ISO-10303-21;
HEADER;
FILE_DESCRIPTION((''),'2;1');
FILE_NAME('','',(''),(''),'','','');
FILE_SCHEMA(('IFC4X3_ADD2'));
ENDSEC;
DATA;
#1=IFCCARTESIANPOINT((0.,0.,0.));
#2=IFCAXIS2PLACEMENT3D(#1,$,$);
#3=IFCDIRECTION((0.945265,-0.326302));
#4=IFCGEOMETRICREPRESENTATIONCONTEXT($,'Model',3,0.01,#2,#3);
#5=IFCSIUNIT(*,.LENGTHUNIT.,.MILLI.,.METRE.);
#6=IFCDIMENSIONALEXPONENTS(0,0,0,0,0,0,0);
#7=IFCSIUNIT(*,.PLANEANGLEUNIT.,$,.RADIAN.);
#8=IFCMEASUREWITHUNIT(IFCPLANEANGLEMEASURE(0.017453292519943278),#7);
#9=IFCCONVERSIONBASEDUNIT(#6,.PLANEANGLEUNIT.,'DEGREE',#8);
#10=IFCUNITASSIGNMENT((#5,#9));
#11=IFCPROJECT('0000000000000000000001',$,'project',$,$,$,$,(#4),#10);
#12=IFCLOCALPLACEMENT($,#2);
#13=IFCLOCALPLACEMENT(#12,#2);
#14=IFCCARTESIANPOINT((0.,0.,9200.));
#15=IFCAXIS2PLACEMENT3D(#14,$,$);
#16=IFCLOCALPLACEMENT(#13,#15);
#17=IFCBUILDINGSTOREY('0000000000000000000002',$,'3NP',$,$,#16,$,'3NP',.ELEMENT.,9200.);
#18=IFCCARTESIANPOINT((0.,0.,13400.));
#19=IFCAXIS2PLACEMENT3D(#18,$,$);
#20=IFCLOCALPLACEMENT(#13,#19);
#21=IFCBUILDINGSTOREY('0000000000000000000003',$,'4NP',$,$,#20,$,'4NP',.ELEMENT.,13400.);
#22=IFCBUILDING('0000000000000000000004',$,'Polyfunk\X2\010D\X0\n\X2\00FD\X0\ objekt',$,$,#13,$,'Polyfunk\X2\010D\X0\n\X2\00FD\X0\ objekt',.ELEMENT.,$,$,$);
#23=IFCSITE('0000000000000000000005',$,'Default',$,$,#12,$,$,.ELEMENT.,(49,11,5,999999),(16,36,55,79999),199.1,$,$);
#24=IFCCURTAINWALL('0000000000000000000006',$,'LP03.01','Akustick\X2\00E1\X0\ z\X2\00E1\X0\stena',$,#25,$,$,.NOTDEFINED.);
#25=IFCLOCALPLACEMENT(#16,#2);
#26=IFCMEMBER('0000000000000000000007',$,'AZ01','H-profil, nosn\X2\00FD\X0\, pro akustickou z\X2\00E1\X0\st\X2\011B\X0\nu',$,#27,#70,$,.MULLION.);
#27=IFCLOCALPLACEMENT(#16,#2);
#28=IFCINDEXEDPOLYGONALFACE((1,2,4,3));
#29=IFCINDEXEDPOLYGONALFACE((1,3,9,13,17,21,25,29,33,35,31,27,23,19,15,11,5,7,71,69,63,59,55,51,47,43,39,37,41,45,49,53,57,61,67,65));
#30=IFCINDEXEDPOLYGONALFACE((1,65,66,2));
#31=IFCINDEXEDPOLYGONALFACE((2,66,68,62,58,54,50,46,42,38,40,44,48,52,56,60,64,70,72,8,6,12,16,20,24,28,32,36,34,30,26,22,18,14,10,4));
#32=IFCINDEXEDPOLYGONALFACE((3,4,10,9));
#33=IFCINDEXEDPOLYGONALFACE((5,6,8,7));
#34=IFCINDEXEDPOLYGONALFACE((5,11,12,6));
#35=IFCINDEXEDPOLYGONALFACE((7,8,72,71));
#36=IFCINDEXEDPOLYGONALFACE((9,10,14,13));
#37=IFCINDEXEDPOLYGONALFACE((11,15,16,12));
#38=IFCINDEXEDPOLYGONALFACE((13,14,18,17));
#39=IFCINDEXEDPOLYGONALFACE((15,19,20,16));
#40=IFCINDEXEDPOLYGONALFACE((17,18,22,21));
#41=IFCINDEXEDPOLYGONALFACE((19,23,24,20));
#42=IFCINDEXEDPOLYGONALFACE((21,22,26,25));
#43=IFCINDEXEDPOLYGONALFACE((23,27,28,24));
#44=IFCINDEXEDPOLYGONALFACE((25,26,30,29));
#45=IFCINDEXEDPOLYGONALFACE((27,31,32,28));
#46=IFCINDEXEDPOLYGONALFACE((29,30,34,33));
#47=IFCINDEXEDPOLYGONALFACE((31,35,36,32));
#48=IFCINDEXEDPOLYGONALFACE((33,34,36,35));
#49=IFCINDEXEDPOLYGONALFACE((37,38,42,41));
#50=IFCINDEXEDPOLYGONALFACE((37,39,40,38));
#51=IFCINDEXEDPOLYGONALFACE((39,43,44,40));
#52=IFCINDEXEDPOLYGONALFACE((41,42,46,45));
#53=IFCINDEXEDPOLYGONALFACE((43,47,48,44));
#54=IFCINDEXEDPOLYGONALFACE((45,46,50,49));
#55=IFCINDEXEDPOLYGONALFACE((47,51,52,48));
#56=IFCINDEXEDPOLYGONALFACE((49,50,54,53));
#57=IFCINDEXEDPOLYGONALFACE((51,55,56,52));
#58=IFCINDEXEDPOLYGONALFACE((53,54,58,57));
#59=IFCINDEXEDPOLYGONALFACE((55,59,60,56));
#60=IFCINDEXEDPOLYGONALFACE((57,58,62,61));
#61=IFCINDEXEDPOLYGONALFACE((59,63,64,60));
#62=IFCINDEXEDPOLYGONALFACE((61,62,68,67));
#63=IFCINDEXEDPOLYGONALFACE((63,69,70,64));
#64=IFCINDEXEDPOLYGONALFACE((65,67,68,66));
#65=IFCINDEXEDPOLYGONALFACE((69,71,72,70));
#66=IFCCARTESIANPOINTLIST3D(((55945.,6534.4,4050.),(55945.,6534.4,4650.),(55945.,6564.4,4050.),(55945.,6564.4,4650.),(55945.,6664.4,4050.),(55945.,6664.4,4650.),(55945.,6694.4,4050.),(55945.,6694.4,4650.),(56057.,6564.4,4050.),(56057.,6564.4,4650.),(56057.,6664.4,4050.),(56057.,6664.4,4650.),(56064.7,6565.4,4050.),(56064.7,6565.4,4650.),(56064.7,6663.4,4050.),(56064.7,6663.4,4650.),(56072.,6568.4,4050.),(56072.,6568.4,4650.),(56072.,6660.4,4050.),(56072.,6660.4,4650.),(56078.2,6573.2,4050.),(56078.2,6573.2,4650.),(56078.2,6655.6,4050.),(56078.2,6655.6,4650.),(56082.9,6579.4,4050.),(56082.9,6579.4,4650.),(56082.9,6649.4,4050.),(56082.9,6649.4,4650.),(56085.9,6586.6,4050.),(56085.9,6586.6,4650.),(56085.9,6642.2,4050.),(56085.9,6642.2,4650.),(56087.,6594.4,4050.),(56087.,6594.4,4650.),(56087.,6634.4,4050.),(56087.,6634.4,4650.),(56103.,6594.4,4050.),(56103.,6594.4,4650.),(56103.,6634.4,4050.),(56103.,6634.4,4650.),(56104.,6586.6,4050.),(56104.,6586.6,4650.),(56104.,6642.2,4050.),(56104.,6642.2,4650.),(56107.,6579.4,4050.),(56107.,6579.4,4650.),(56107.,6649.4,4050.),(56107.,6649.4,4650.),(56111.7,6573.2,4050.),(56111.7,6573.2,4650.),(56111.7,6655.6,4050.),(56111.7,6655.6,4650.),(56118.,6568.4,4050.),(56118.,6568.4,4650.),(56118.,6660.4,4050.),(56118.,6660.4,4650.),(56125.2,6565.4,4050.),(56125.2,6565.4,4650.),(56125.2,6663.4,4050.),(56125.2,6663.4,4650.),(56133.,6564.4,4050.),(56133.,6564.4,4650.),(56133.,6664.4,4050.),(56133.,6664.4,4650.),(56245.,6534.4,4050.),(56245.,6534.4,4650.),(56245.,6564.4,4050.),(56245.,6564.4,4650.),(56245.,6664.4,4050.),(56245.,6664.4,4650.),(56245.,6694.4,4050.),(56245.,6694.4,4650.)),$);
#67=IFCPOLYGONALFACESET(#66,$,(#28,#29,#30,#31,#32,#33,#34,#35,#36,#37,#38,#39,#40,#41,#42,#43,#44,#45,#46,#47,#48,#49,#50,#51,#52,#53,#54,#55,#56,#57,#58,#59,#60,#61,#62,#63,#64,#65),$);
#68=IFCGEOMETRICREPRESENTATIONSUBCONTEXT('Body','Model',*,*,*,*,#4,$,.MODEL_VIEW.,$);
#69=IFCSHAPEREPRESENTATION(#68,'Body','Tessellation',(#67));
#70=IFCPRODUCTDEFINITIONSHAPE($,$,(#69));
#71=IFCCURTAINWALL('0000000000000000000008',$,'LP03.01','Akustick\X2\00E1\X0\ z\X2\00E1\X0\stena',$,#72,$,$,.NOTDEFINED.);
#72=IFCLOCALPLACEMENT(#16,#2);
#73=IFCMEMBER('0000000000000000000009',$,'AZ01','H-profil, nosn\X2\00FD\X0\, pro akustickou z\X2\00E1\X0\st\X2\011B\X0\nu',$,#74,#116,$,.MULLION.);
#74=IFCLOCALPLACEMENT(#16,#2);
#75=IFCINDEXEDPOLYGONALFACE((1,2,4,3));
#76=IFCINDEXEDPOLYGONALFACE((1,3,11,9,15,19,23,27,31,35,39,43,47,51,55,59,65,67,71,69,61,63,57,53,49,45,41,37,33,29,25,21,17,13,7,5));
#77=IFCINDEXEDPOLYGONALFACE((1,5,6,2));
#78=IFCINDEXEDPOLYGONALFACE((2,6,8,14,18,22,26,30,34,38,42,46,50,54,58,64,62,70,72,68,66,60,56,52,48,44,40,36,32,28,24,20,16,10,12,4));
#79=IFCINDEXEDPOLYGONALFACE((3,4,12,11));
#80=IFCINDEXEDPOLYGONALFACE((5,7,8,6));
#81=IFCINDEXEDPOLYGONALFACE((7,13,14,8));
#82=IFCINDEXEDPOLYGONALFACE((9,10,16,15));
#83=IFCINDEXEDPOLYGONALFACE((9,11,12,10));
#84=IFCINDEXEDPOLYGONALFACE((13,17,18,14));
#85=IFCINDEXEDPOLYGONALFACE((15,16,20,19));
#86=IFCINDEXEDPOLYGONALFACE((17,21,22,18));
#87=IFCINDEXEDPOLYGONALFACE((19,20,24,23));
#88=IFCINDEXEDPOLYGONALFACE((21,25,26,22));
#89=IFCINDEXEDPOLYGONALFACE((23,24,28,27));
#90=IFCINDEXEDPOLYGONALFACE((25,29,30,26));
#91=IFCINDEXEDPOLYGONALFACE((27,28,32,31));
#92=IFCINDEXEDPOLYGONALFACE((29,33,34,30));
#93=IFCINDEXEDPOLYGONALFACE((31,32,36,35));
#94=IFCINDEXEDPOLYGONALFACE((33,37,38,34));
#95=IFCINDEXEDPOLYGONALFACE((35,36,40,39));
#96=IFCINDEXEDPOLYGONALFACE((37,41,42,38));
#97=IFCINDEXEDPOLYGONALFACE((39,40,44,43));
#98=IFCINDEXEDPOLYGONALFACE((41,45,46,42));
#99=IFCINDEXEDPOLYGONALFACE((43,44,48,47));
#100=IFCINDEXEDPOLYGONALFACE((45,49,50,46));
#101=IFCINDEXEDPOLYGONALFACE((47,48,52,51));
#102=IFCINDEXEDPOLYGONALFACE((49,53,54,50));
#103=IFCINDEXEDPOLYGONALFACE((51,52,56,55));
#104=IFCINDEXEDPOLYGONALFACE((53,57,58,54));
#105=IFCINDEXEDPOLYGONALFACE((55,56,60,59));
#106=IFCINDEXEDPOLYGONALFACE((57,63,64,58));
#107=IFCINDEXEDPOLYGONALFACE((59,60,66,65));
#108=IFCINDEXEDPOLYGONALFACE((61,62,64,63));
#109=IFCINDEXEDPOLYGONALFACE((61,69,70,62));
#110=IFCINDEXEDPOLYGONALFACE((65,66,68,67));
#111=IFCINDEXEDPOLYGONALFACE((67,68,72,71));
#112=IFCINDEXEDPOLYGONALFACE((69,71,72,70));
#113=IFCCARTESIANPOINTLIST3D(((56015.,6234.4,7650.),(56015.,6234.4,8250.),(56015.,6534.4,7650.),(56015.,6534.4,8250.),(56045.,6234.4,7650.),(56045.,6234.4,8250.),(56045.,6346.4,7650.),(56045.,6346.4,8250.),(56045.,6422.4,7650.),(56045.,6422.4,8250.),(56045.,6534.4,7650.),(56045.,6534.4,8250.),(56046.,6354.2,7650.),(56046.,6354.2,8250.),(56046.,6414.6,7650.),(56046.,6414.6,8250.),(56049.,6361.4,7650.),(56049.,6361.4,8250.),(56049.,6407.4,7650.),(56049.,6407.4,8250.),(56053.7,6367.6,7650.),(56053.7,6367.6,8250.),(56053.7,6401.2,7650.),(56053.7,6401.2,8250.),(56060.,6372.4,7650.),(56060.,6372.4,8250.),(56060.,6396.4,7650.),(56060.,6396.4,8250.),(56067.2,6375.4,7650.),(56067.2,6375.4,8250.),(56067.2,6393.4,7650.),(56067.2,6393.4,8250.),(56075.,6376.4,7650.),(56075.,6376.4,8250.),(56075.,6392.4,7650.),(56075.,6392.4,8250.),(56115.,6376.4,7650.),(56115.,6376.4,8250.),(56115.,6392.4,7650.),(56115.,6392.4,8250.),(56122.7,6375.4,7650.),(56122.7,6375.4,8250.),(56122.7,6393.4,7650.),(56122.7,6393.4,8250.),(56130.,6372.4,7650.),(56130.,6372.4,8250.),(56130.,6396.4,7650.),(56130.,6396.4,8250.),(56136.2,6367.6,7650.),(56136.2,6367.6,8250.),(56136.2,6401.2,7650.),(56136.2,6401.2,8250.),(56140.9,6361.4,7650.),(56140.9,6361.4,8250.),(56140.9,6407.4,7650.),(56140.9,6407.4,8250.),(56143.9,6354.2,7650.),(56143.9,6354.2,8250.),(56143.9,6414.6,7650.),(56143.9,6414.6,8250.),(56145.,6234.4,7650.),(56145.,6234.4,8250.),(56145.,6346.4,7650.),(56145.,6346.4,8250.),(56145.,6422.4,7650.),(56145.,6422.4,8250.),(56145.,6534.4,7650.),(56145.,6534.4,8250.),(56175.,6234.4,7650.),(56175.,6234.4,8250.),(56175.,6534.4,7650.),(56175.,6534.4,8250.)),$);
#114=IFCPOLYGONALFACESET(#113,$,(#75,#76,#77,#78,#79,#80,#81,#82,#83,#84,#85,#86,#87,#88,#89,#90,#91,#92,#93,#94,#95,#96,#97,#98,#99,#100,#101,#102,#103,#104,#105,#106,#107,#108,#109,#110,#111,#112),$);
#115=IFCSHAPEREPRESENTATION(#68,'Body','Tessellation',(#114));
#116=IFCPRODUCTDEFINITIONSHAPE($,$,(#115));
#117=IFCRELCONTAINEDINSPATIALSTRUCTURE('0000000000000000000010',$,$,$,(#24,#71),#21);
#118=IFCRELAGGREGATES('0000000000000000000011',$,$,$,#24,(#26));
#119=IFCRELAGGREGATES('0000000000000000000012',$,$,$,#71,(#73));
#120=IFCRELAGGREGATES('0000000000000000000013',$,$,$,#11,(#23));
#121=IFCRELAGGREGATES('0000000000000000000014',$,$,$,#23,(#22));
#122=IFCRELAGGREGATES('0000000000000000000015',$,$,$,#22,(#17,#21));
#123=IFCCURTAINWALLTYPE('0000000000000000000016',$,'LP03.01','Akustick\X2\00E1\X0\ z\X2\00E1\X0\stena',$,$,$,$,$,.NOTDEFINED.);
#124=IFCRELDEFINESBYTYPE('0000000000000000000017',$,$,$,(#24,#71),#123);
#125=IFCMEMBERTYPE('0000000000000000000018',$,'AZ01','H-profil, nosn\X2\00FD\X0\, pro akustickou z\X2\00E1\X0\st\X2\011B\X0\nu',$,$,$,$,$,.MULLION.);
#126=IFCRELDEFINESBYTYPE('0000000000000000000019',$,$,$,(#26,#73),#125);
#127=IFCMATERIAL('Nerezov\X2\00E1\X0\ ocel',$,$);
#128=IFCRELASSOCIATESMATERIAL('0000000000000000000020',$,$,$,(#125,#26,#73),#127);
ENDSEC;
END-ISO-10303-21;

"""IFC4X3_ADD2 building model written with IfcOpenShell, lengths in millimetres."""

from ifc_helpers import new_model, entity, si_unit, converted_unit, direction, frame, frame_2d, origin, place, context, subcontext, project, spatial, polyline, circle_curve, parameter, trimmed, segment, composite_curve, outline, extrude, source, transform, mapped, material, material_profile, profile_set, profile_usage, type_object, element, aggregate, save


model = new_model("IFC4X3_ADD2")

# Units and contexts
model_context = context("Model", 3, precision=0.01, world=origin(), true_north=direction((0.945265, -0.326302)))
body_context = subcontext(model_context, "Body", "Model", "MODEL_VIEW")
ifc_project = project(units=[si_unit("LENGTHUNIT", "METRE", prefix="MILLI"), converted_unit("PLANEANGLEUNIT", "DEGREE", entity("IfcPlaneAngleMeasure", 0.017453292519943278), si_unit("PLANEANGLEUNIT", "RADIAN"), dimensions=[0, 0, 0, 0, 0, 0, 0])], contexts=[model_context])

# Site, building, storey
site_placement = place(None, origin())
site = spatial("IfcSite", under=ifc_project, at=site_placement, Name="Default", CompositionType="ELEMENT", RefLatitude=(49, 11, 5, 999999), RefLongitude=(16, 36, 55, 79999), RefElevation=199.1)
building_placement = place(site_placement, origin())
building = spatial("IfcBuilding", under=site, at=building_placement, Name="Polyfunkčný objekt", LongName="Polyfunkčný objekt", CompositionType="ELEMENT")
storey_1_placement = place(building_placement, frame((0.0, 0.0, 9200.0)))
storey_1 = spatial("IfcBuildingStorey", under=building, at=storey_1_placement, Name="3NP", LongName="3NP", CompositionType="ELEMENT", Elevation=9200.0)

# Shared definitions
storey_2_placement = place(building_placement, frame((0.0, 0.0, 13400.0)))
storey_2 = spatial("IfcBuildingStorey", under=building, at=storey_2_placement, Name="4NP", LongName="4NP", CompositionType="ELEMENT", Elevation=13400.0)

# Curtain walls, members
curtain_wall_type_1 = type_object("IfcCurtainWallType", Name="LP03.01", Description="Akustická zástena", PredefinedType="NOTDEFINED")
curtain_wall_1_placement = place(storey_2_placement, frame((0.0, 0.0, -13400.0)))
curtain_wall_1 = element("IfcCurtainWall", 1, at=curtain_wall_1_placement, inside=storey_2, type_object=curtain_wall_type_1, Name="LP03.01", Description="Akustická zástena", PredefinedType="NOTDEFINED")
ifc_material_1 = material(Name="Nerezová ocel")
ifc_material_profile_1 = material_profile(ifc_material_1, outline(composite_curve([segment(polyline([(50.0, -150.0), (80.0, -150.0)]), True, "CONTINUOUS"), segment(polyline([(80.0, -150.0), (80.0, 150.0)]), True, "CONTINUOUS"), segment(polyline([(80.0, 150.0), (50.0, 150.0)]), True, "CONTINUOUS"), segment(polyline([(50.0, 150.0), (50.0, 38.0)]), True, "CONTINUOUS"), segment(trimmed(circle_curve(frame_2d((20.0, 38.0), x_axis=(0.0, 1.0)), 30.0), [parameter(180.0)], [parameter(270.0)], True, "PARAMETER"), False, "CONTINUOUS"), segment(polyline([(20.0, 8.0), (-20.0, 8.0)]), True, "CONTINUOUS"), segment(trimmed(circle_curve(frame_2d((-20.0, 38.0), x_axis=(0.0, 1.0)), 30.0), [parameter(90.0)], [parameter(180.0)], True, "PARAMETER"), False, "CONTINUOUS"), segment(polyline([(-50.0, 38.0), (-50.0, 150.0)]), True, "CONTINUOUS"), segment(polyline([(-50.0, 150.0), (-80.0, 150.0)]), True, "CONTINUOUS"), segment(polyline([(-80.0, 150.0), (-80.0, -150.0)]), True, "CONTINUOUS"), segment(polyline([(-80.0, -150.0), (-50.0, -150.0)]), True, "CONTINUOUS"), segment(polyline([(-50.0, -150.0), (-50.0, -38.0)]), True, "CONTINUOUS"), segment(trimmed(circle_curve(frame_2d((-20.0, -38.0), x_axis=(0.0, 1.0)), 30.0), [parameter(0.0)], [parameter(90.0)], True, "PARAMETER"), False, "CONTINUOUS"), segment(polyline([(-20.0, -8.0), (20.0, -8.0)]), True, "CONTINUOUS"), segment(trimmed(circle_curve(frame_2d((20.0, -38.0), x_axis=(0.0, 1.0)), 30.0), [parameter(270.0)], [parameter(0.0)], True, "PARAMETER"), False, "CONTINUOUS"), segment(polyline([(50.0, -38.0), (50.0, -150.0)]), True, "CONTINUOUS")], self_intersect=False)), Name="Profil zástena")
ifc_profile_set_1 = profile_set([ifc_material_profile_1], Name="Profil zástena")
ifc_profile_usage_1 = profile_usage(ifc_profile_set_1)
member_type_1 = type_object("IfcMemberType", Name="AZ01", Description="H-profil, nosný, pro akustickou zástěnu", PredefinedType="MULLION", material=ifc_profile_set_1)
shared_shape_1 = source(origin(), body_context, "Body", "SweptSolid", [
    extrude(outline(composite_curve([segment(polyline([(50.0, -150.0), (80.0, -150.0)]), True, "CONTINUOUS"), segment(polyline([(80.0, -150.0), (80.0, 150.0)]), True, "CONTINUOUS"), segment(polyline([(80.0, 150.0), (50.0, 150.0)]), True, "CONTINUOUS"), segment(polyline([(50.0, 150.0), (50.0, 38.0)]), True, "CONTINUOUS"), segment(trimmed(circle_curve(frame_2d((20.0, 38.0), x_axis=(0.0, 1.0)), 30.0), [parameter(180.0)], [parameter(270.0)], True, "PARAMETER"), False, "CONTINUOUS"), segment(polyline([(20.0, 8.0), (-20.0, 8.0)]), True, "CONTINUOUS"), segment(trimmed(circle_curve(frame_2d((-20.0, 38.0), x_axis=(0.0, 1.0)), 30.0), [parameter(90.0)], [parameter(180.0)], True, "PARAMETER"), False, "CONTINUOUS"), segment(polyline([(-50.0, 38.0), (-50.0, 150.0)]), True, "CONTINUOUS"), segment(polyline([(-50.0, 150.0), (-80.0, 150.0)]), True, "CONTINUOUS"), segment(polyline([(-80.0, 150.0), (-80.0, -150.0)]), True, "CONTINUOUS"), segment(polyline([(-80.0, -150.0), (-50.0, -150.0)]), True, "CONTINUOUS"), segment(polyline([(-50.0, -150.0), (-50.0, -38.0)]), True, "CONTINUOUS"), segment(trimmed(circle_curve(frame_2d((-20.0, -38.0), x_axis=(0.0, 1.0)), 30.0), [parameter(0.0)], [parameter(90.0)], True, "PARAMETER"), False, "CONTINUOUS"), segment(polyline([(-20.0, -8.0), (20.0, -8.0)]), True, "CONTINUOUS"), segment(trimmed(circle_curve(frame_2d((20.0, -38.0), x_axis=(0.0, 1.0)), 30.0), [parameter(270.0)], [parameter(0.0)], True, "PARAMETER"), False, "CONTINUOUS"), segment(polyline([(50.0, -38.0), (50.0, -150.0)]), True, "CONTINUOUS")], self_intersect=False)), frame((-150.0, 0.0, -600.0), z_axis=(0.0, 0.0, 1.0), x_axis=(0.0, -1.0, 0.0)), (0.0, 0.0, 1.0), 600.0),
])
member_1_placement = place(curtain_wall_1_placement, frame((56245.0, 6614.4, 13250.0), z_axis=(0.0, 0.0, -1.0), x_axis=(1.0, 0.0, 0.0)))
member_1 = element("IfcMember", 2, at=member_1_placement, type_object=member_type_1, material=ifc_profile_usage_1, Name="AZ01", Description="H-profil, nosný, pro akustickou zástěnu", PredefinedType="MULLION", context=body_context, shape_type="MappedRepresentation", body=[
    mapped(shared_shape_1, transform((0.0, 0.0, 0.0), scale=1.0)),
])
aggregate(curtain_wall_1, [member_1])
curtain_wall_2_placement = place(storey_2_placement, frame((0.0, 0.0, -13400.0)))
curtain_wall_2 = element("IfcCurtainWall", 3, at=curtain_wall_2_placement, inside=storey_2, type_object=curtain_wall_type_1, Name="LP03.01", Description="Akustická zástena", PredefinedType="NOTDEFINED")
shared_shape_2 = source(origin(), body_context, "Body", "SweptSolid", [
    extrude(outline(composite_curve([segment(polyline([(-150.0, -50.0), (-150.0, -80.0)]), True, "CONTINUOUS"), segment(polyline([(-150.0, -80.0), (150.0, -80.0)]), True, "CONTINUOUS"), segment(polyline([(150.0, -80.0), (150.0, -50.0)]), True, "CONTINUOUS"), segment(polyline([(150.0, -50.0), (38.0, -50.0)]), True, "CONTINUOUS"), segment(trimmed(circle_curve(frame_2d((38.0, -20.0), x_axis=(1.0, 0.0)), 30.0), [parameter(180.0)], [parameter(270.0)], True, "PARAMETER"), False, "CONTINUOUS"), segment(polyline([(8.0, -20.0), (8.0, 20.0)]), True, "CONTINUOUS"), segment(trimmed(circle_curve(frame_2d((38.0, 20.0), x_axis=(1.0, 0.0)), 30.0), [parameter(90.0)], [parameter(180.0)], True, "PARAMETER"), False, "CONTINUOUS"), segment(polyline([(38.0, 50.0), (150.0, 50.0)]), True, "CONTINUOUS"), segment(polyline([(150.0, 50.0), (150.0, 80.0)]), True, "CONTINUOUS"), segment(polyline([(150.0, 80.0), (-150.0, 80.0)]), True, "CONTINUOUS"), segment(polyline([(-150.0, 80.0), (-150.0, 50.0)]), True, "CONTINUOUS"), segment(polyline([(-150.0, 50.0), (-38.0, 50.0)]), True, "CONTINUOUS"), segment(trimmed(circle_curve(frame_2d((-38.0, 20.0), x_axis=(1.0, 0.0)), 30.0), [parameter(0.0)], [parameter(90.0)], True, "PARAMETER"), False, "CONTINUOUS"), segment(polyline([(-8.0, 20.0), (-8.0, -20.0)]), True, "CONTINUOUS"), segment(trimmed(circle_curve(frame_2d((-38.0, -20.0), x_axis=(1.0, 0.0)), 30.0), [parameter(270.0)], [parameter(0.0)], True, "PARAMETER"), False, "CONTINUOUS"), segment(polyline([(-38.0, -50.0), (-150.0, -50.0)]), True, "CONTINUOUS")], self_intersect=False)), frame((-150.0, 0.0, -600.0), z_axis=(0.0, 0.0, -1.0), x_axis=(1.0, 0.0, 0.0)), (0.0, 0.0, -1.0), 600.0),
])
member_2_placement = place(curtain_wall_2_placement, frame((56095.0, 6534.4, 16850.0), z_axis=(0.0, 0.0, -1.0), x_axis=(0.0, 1.0, 0.0)))
member_2 = element("IfcMember", 4, at=member_2_placement, type_object=member_type_1, material=ifc_profile_usage_1, Name="AZ01", Description="H-profil, nosný, pro akustickou zástěnu", PredefinedType="MULLION", context=body_context, shape_type="MappedRepresentation", body=[
    mapped(shared_shape_2, transform((0.0, 0.0, 0.0), scale=1.0)),
])

aggregate(curtain_wall_2, [member_2])

save(model, "model.ifc")
